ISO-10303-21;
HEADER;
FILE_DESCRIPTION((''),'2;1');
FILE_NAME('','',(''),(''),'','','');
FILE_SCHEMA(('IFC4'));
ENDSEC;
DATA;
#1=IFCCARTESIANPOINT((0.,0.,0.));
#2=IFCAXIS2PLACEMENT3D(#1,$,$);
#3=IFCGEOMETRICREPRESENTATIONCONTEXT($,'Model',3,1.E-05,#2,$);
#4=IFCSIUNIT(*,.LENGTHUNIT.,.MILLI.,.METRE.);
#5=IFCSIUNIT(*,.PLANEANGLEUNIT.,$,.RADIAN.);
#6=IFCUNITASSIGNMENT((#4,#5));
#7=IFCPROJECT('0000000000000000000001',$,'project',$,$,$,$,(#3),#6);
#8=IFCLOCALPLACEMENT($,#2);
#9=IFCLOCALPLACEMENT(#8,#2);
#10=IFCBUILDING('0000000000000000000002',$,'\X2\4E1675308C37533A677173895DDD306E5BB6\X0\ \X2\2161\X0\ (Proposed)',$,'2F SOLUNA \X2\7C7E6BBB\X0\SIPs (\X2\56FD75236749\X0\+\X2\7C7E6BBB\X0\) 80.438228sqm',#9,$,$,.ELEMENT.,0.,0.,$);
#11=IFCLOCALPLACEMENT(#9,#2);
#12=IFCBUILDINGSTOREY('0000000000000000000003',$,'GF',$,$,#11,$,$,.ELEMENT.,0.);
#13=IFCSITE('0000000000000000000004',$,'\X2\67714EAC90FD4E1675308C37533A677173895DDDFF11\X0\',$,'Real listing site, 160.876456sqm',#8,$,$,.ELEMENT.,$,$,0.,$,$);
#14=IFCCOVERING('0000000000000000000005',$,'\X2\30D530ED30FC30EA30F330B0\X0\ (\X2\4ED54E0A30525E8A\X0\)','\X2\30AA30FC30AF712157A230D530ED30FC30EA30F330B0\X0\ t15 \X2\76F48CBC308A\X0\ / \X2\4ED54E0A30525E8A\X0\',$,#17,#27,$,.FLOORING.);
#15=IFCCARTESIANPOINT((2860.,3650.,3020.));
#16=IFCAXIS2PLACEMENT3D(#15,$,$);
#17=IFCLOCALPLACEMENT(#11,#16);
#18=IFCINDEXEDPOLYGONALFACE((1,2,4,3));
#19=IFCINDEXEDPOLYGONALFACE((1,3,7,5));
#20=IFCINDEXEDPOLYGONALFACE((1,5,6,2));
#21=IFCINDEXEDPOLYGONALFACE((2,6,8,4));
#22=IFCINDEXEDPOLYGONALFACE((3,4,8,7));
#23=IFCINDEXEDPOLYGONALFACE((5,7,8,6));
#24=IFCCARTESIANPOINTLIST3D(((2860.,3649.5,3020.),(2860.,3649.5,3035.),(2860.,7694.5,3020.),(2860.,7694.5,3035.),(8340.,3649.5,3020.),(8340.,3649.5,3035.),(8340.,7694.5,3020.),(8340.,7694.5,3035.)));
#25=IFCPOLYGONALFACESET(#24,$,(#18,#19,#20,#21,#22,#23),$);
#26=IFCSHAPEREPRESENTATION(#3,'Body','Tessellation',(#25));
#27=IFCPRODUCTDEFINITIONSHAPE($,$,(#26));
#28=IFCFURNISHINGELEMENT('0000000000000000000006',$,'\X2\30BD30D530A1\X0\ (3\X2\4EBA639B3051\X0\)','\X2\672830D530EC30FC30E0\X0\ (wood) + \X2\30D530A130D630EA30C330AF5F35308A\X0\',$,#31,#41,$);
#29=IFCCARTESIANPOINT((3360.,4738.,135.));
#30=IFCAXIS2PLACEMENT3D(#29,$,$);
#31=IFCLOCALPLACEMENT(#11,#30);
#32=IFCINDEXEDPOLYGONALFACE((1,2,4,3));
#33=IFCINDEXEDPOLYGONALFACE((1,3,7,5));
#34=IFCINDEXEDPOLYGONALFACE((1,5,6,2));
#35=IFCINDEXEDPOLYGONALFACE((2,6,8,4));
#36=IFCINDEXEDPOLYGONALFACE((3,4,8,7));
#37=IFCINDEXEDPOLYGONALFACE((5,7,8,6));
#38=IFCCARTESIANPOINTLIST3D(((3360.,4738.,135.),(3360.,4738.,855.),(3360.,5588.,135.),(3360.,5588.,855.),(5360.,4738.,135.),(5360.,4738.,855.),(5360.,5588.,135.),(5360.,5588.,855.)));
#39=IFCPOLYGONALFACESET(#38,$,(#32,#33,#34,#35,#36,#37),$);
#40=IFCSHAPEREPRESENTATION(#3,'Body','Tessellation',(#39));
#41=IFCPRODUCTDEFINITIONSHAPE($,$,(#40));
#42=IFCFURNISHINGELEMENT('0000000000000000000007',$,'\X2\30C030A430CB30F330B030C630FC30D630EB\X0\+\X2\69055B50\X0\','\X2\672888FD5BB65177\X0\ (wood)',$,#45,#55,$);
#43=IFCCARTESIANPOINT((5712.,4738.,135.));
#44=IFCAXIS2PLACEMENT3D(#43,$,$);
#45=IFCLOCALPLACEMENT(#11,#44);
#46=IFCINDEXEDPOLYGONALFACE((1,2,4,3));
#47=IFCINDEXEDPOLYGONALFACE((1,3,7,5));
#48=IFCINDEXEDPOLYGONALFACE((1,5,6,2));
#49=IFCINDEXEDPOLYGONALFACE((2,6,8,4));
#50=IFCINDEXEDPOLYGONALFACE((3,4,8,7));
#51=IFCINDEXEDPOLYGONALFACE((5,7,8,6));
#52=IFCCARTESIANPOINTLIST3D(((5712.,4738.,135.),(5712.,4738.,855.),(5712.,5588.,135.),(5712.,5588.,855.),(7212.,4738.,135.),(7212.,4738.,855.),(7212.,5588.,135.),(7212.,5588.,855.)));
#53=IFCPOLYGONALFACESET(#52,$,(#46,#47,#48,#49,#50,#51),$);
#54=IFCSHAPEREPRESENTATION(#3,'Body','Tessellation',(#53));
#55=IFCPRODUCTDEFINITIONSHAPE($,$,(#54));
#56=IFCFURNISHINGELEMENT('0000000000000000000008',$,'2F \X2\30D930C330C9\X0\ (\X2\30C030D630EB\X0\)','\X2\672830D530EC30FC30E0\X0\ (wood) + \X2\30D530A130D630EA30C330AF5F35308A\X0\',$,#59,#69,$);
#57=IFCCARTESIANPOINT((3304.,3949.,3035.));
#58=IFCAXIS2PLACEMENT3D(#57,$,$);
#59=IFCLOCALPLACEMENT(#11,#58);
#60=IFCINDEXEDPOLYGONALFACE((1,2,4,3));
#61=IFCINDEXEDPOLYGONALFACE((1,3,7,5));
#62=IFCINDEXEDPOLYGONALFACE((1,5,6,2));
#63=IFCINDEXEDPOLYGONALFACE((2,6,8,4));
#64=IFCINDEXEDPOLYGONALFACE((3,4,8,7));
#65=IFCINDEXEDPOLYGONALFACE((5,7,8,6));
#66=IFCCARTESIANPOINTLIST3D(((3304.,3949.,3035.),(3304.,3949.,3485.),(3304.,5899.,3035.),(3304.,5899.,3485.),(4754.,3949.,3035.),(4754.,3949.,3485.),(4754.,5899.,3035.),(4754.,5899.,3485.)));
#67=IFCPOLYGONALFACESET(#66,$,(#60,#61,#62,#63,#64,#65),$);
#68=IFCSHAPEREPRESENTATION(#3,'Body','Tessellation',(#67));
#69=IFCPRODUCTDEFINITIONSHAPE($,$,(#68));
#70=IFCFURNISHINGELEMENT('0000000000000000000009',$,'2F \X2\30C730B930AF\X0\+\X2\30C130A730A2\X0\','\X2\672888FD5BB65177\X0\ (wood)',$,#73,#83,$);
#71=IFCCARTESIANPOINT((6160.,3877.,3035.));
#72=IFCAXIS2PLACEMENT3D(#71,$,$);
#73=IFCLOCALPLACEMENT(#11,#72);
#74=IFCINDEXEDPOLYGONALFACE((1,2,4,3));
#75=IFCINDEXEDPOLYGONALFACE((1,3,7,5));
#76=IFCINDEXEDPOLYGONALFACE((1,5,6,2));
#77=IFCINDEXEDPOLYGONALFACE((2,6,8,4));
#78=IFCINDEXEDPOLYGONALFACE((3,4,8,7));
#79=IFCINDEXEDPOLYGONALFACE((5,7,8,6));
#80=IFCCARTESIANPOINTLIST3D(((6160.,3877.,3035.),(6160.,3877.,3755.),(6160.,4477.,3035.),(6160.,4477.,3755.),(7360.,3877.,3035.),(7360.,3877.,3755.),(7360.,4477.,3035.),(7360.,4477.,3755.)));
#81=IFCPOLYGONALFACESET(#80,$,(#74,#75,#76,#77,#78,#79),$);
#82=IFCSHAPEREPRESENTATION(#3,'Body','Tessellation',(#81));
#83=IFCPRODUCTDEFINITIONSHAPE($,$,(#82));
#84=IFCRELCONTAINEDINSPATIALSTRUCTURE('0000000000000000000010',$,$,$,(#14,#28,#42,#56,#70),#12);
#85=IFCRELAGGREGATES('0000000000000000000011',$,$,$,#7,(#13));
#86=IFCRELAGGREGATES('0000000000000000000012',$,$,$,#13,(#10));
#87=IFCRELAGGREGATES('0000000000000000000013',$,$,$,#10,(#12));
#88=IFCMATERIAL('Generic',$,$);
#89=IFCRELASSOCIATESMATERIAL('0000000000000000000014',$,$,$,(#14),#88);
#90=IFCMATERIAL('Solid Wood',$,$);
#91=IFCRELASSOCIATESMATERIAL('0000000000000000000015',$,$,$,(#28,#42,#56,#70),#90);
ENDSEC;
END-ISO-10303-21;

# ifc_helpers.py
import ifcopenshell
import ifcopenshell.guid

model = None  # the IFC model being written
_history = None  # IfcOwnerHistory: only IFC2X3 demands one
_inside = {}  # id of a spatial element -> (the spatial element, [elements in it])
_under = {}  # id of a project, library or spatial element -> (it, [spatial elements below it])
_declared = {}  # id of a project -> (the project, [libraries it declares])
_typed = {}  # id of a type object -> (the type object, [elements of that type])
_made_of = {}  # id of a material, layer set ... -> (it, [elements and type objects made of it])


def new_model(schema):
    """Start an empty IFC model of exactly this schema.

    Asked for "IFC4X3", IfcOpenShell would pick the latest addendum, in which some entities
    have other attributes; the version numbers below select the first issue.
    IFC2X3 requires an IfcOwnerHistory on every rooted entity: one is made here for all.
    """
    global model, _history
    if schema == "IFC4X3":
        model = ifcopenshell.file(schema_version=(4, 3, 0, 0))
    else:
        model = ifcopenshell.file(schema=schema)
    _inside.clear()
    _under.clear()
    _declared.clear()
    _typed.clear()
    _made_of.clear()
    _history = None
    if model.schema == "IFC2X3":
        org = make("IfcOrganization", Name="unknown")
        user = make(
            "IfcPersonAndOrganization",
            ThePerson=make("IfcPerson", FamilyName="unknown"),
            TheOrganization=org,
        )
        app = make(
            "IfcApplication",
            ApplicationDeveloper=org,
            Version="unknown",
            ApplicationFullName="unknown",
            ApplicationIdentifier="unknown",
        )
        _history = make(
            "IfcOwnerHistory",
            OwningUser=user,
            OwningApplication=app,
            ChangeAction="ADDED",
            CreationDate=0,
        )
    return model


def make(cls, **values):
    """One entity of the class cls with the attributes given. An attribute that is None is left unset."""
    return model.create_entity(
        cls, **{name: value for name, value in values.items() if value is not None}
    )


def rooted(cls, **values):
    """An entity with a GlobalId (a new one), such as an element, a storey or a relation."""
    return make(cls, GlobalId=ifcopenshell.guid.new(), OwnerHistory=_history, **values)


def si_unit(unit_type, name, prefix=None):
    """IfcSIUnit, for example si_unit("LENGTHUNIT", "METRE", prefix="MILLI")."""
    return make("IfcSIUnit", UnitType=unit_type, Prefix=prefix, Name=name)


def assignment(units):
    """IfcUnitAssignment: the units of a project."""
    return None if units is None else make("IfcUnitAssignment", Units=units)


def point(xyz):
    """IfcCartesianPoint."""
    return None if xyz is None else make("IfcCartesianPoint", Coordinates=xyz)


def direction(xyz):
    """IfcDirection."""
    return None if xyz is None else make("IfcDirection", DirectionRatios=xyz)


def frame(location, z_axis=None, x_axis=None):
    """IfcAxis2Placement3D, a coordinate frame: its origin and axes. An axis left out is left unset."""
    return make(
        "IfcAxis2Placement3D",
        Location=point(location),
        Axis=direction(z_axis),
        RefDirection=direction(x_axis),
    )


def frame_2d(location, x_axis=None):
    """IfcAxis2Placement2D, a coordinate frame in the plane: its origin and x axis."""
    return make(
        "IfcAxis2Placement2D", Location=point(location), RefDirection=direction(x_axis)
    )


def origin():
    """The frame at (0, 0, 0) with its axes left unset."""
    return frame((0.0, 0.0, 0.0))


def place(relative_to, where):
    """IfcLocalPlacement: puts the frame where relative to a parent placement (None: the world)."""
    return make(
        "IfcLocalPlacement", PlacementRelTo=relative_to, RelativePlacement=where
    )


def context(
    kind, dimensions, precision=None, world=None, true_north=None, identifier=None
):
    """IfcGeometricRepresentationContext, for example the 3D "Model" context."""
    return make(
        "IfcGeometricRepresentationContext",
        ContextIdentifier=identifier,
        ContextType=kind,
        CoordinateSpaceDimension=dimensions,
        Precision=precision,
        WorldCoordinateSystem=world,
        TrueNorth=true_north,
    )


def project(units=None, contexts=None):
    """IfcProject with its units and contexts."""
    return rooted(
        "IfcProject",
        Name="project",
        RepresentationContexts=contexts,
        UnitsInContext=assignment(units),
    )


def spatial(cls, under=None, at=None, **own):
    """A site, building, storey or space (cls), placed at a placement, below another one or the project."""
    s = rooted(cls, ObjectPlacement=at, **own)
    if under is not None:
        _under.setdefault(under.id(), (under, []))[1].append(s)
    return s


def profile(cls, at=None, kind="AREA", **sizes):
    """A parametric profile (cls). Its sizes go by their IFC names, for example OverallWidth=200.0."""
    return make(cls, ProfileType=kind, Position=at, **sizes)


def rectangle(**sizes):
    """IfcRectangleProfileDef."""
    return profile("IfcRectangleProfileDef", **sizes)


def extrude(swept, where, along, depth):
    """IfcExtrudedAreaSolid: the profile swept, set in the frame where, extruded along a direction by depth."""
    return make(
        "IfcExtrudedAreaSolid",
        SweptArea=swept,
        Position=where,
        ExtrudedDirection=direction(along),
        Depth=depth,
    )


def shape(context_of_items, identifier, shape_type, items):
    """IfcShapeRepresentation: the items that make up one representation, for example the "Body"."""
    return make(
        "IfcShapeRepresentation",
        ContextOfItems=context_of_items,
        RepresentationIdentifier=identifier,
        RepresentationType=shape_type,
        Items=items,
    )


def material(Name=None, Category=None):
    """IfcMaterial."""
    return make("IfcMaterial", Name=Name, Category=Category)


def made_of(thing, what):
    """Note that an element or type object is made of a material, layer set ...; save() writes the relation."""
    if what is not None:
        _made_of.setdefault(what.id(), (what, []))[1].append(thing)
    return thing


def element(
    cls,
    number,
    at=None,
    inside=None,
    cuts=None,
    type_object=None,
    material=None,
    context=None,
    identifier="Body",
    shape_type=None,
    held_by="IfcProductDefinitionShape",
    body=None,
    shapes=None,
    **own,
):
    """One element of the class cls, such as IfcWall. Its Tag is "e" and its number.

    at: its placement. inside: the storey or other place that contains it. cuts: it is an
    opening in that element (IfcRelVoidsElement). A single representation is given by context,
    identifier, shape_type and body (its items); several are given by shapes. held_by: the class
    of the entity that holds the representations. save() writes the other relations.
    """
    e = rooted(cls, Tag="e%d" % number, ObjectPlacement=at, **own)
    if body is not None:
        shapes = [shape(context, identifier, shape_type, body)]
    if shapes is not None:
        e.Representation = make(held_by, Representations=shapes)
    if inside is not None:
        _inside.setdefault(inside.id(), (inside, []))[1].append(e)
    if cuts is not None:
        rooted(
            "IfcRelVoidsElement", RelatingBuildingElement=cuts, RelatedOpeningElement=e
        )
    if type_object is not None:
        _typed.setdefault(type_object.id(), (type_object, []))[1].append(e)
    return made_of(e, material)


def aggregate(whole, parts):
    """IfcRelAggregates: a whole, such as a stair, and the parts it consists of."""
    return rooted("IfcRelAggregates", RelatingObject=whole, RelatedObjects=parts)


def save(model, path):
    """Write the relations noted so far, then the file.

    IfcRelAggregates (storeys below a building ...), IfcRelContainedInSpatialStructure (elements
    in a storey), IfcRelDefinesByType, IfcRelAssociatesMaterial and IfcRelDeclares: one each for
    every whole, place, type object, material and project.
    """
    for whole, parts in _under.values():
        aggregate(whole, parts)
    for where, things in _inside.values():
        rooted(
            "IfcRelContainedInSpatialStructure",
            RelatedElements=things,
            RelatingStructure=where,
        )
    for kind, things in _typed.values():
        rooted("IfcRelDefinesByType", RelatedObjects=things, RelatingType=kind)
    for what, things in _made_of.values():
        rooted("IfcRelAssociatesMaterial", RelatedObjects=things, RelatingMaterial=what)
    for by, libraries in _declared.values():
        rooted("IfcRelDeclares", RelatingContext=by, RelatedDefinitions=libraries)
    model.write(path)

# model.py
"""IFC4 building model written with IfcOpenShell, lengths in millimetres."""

from ifc_helpers import new_model, si_unit, frame, frame_2d, origin, place, context, project, spatial, rectangle, extrude, material, element, save


model = new_model("IFC4")

# Units and contexts
model_context = context("Model", 3, precision=1e-05, world=origin())
ifc_project = project(units=[si_unit("LENGTHUNIT", "METRE", prefix="MILLI"), si_unit("PLANEANGLEUNIT", "RADIAN")], contexts=[model_context])

# Site, building, storey
site_placement = place(None, origin())
site = spatial("IfcSite", under=ifc_project, at=site_placement, Name="東京都世田谷区東玉川１", ObjectType="Real listing site, 160.876456sqm", CompositionType="ELEMENT", RefElevation=0.0)
building_placement = place(site_placement, origin())
building = spatial("IfcBuilding", under=site, at=building_placement, Name="世田谷区東玉川の家 Ⅱ (Proposed)", ObjectType="2F SOLUNA 籾殻SIPs (国産杉+籾殻) 80.438228sqm", CompositionType="ELEMENT", ElevationOfRefHeight=0.0, ElevationOfTerrain=0.0)
storey_placement = place(building_placement, origin())
storey = spatial("IfcBuildingStorey", under=building, at=storey_placement, Name="GF", CompositionType="ELEMENT", Elevation=0.0)

# Shared definitions
ifc_material_1 = material(Name="Solid Wood")

# Covering
ifc_material_2 = material(Name="Generic")
covering_placement = place(storey_placement, frame((2860.0, 3650.0, 3020.0)))
element("IfcCovering", 1, at=covering_placement, inside=storey, material=ifc_material_2, Name="フローリング (仕上げ床)", Description="オーク無垢フローリング t15 直貼り / 仕上げ床", PredefinedType="FLOORING", context=model_context, shape_type="SweptSolid", body=[
    extrude(rectangle(XDim=5480.0, YDim=4045.0, at=frame_2d((2740.0, 2022.0))), frame((2860.0, 3650.0, 3020.0)), (0.0, 0.0, 1.0), 15.0),
])

# Furnishing elements
furnishing_1_placement = place(storey_placement, frame((3360.0, 4738.0, 135.0)))
element("IfcFurnishingElement", 2, at=furnishing_1_placement, inside=storey, material=ifc_material_1, Name="ソファ (3人掛け)", Description="木フレーム (wood) + ファブリック張り", context=model_context, shape_type="SweptSolid", body=[
    extrude(rectangle(XDim=2000.0, YDim=850.0, at=frame_2d((1000.0, 425.0))), frame((3360.0, 4738.0, 135.0)), (0.0, 0.0, 1.0), 720.0),
])
furnishing_2_placement = place(storey_placement, frame((5712.0, 4738.0, 135.0)))
element("IfcFurnishingElement", 3, at=furnishing_2_placement, inside=storey, material=ifc_material_1, Name="ダイニングテーブル+椅子", Description="木製家具 (wood)", context=model_context, shape_type="SweptSolid", body=[
    extrude(rectangle(XDim=1500.0, YDim=850.0, at=frame_2d((750.0, 425.0))), frame((5712.0, 4738.0, 135.0)), (0.0, 0.0, 1.0), 720.0),
])
furnishing_3_placement = place(storey_placement, frame((3304.0, 3949.0, 3035.0)))
element("IfcFurnishingElement", 4, at=furnishing_3_placement, inside=storey, material=ifc_material_1, Name="2F ベッド (ダブル)", Description="木フレーム (wood) + ファブリック張り", context=model_context, shape_type="SweptSolid", body=[
    extrude(rectangle(XDim=1450.0, YDim=1950.0, at=frame_2d((725.0, 975.0))), frame((3304.0, 3949.0, 3035.0)), (0.0, 0.0, 1.0), 450.0),
])
furnishing_4_placement = place(storey_placement, frame((6160.0, 3877.0, 3035.0)))
element("IfcFurnishingElement", 5, at=furnishing_4_placement, inside=storey, material=ifc_material_1, Name="2F デスク+チェア", Description="木製家具 (wood)", context=model_context, shape_type="SweptSolid", body=[
    extrude(rectangle(XDim=1200.0, YDim=600.0, at=frame_2d((600.0, 300.0))), frame((6160.0, 3877.0, 3035.0)), (0.0, 0.0, 1.0), 720.0),
])

save(model, "model.ifc")
